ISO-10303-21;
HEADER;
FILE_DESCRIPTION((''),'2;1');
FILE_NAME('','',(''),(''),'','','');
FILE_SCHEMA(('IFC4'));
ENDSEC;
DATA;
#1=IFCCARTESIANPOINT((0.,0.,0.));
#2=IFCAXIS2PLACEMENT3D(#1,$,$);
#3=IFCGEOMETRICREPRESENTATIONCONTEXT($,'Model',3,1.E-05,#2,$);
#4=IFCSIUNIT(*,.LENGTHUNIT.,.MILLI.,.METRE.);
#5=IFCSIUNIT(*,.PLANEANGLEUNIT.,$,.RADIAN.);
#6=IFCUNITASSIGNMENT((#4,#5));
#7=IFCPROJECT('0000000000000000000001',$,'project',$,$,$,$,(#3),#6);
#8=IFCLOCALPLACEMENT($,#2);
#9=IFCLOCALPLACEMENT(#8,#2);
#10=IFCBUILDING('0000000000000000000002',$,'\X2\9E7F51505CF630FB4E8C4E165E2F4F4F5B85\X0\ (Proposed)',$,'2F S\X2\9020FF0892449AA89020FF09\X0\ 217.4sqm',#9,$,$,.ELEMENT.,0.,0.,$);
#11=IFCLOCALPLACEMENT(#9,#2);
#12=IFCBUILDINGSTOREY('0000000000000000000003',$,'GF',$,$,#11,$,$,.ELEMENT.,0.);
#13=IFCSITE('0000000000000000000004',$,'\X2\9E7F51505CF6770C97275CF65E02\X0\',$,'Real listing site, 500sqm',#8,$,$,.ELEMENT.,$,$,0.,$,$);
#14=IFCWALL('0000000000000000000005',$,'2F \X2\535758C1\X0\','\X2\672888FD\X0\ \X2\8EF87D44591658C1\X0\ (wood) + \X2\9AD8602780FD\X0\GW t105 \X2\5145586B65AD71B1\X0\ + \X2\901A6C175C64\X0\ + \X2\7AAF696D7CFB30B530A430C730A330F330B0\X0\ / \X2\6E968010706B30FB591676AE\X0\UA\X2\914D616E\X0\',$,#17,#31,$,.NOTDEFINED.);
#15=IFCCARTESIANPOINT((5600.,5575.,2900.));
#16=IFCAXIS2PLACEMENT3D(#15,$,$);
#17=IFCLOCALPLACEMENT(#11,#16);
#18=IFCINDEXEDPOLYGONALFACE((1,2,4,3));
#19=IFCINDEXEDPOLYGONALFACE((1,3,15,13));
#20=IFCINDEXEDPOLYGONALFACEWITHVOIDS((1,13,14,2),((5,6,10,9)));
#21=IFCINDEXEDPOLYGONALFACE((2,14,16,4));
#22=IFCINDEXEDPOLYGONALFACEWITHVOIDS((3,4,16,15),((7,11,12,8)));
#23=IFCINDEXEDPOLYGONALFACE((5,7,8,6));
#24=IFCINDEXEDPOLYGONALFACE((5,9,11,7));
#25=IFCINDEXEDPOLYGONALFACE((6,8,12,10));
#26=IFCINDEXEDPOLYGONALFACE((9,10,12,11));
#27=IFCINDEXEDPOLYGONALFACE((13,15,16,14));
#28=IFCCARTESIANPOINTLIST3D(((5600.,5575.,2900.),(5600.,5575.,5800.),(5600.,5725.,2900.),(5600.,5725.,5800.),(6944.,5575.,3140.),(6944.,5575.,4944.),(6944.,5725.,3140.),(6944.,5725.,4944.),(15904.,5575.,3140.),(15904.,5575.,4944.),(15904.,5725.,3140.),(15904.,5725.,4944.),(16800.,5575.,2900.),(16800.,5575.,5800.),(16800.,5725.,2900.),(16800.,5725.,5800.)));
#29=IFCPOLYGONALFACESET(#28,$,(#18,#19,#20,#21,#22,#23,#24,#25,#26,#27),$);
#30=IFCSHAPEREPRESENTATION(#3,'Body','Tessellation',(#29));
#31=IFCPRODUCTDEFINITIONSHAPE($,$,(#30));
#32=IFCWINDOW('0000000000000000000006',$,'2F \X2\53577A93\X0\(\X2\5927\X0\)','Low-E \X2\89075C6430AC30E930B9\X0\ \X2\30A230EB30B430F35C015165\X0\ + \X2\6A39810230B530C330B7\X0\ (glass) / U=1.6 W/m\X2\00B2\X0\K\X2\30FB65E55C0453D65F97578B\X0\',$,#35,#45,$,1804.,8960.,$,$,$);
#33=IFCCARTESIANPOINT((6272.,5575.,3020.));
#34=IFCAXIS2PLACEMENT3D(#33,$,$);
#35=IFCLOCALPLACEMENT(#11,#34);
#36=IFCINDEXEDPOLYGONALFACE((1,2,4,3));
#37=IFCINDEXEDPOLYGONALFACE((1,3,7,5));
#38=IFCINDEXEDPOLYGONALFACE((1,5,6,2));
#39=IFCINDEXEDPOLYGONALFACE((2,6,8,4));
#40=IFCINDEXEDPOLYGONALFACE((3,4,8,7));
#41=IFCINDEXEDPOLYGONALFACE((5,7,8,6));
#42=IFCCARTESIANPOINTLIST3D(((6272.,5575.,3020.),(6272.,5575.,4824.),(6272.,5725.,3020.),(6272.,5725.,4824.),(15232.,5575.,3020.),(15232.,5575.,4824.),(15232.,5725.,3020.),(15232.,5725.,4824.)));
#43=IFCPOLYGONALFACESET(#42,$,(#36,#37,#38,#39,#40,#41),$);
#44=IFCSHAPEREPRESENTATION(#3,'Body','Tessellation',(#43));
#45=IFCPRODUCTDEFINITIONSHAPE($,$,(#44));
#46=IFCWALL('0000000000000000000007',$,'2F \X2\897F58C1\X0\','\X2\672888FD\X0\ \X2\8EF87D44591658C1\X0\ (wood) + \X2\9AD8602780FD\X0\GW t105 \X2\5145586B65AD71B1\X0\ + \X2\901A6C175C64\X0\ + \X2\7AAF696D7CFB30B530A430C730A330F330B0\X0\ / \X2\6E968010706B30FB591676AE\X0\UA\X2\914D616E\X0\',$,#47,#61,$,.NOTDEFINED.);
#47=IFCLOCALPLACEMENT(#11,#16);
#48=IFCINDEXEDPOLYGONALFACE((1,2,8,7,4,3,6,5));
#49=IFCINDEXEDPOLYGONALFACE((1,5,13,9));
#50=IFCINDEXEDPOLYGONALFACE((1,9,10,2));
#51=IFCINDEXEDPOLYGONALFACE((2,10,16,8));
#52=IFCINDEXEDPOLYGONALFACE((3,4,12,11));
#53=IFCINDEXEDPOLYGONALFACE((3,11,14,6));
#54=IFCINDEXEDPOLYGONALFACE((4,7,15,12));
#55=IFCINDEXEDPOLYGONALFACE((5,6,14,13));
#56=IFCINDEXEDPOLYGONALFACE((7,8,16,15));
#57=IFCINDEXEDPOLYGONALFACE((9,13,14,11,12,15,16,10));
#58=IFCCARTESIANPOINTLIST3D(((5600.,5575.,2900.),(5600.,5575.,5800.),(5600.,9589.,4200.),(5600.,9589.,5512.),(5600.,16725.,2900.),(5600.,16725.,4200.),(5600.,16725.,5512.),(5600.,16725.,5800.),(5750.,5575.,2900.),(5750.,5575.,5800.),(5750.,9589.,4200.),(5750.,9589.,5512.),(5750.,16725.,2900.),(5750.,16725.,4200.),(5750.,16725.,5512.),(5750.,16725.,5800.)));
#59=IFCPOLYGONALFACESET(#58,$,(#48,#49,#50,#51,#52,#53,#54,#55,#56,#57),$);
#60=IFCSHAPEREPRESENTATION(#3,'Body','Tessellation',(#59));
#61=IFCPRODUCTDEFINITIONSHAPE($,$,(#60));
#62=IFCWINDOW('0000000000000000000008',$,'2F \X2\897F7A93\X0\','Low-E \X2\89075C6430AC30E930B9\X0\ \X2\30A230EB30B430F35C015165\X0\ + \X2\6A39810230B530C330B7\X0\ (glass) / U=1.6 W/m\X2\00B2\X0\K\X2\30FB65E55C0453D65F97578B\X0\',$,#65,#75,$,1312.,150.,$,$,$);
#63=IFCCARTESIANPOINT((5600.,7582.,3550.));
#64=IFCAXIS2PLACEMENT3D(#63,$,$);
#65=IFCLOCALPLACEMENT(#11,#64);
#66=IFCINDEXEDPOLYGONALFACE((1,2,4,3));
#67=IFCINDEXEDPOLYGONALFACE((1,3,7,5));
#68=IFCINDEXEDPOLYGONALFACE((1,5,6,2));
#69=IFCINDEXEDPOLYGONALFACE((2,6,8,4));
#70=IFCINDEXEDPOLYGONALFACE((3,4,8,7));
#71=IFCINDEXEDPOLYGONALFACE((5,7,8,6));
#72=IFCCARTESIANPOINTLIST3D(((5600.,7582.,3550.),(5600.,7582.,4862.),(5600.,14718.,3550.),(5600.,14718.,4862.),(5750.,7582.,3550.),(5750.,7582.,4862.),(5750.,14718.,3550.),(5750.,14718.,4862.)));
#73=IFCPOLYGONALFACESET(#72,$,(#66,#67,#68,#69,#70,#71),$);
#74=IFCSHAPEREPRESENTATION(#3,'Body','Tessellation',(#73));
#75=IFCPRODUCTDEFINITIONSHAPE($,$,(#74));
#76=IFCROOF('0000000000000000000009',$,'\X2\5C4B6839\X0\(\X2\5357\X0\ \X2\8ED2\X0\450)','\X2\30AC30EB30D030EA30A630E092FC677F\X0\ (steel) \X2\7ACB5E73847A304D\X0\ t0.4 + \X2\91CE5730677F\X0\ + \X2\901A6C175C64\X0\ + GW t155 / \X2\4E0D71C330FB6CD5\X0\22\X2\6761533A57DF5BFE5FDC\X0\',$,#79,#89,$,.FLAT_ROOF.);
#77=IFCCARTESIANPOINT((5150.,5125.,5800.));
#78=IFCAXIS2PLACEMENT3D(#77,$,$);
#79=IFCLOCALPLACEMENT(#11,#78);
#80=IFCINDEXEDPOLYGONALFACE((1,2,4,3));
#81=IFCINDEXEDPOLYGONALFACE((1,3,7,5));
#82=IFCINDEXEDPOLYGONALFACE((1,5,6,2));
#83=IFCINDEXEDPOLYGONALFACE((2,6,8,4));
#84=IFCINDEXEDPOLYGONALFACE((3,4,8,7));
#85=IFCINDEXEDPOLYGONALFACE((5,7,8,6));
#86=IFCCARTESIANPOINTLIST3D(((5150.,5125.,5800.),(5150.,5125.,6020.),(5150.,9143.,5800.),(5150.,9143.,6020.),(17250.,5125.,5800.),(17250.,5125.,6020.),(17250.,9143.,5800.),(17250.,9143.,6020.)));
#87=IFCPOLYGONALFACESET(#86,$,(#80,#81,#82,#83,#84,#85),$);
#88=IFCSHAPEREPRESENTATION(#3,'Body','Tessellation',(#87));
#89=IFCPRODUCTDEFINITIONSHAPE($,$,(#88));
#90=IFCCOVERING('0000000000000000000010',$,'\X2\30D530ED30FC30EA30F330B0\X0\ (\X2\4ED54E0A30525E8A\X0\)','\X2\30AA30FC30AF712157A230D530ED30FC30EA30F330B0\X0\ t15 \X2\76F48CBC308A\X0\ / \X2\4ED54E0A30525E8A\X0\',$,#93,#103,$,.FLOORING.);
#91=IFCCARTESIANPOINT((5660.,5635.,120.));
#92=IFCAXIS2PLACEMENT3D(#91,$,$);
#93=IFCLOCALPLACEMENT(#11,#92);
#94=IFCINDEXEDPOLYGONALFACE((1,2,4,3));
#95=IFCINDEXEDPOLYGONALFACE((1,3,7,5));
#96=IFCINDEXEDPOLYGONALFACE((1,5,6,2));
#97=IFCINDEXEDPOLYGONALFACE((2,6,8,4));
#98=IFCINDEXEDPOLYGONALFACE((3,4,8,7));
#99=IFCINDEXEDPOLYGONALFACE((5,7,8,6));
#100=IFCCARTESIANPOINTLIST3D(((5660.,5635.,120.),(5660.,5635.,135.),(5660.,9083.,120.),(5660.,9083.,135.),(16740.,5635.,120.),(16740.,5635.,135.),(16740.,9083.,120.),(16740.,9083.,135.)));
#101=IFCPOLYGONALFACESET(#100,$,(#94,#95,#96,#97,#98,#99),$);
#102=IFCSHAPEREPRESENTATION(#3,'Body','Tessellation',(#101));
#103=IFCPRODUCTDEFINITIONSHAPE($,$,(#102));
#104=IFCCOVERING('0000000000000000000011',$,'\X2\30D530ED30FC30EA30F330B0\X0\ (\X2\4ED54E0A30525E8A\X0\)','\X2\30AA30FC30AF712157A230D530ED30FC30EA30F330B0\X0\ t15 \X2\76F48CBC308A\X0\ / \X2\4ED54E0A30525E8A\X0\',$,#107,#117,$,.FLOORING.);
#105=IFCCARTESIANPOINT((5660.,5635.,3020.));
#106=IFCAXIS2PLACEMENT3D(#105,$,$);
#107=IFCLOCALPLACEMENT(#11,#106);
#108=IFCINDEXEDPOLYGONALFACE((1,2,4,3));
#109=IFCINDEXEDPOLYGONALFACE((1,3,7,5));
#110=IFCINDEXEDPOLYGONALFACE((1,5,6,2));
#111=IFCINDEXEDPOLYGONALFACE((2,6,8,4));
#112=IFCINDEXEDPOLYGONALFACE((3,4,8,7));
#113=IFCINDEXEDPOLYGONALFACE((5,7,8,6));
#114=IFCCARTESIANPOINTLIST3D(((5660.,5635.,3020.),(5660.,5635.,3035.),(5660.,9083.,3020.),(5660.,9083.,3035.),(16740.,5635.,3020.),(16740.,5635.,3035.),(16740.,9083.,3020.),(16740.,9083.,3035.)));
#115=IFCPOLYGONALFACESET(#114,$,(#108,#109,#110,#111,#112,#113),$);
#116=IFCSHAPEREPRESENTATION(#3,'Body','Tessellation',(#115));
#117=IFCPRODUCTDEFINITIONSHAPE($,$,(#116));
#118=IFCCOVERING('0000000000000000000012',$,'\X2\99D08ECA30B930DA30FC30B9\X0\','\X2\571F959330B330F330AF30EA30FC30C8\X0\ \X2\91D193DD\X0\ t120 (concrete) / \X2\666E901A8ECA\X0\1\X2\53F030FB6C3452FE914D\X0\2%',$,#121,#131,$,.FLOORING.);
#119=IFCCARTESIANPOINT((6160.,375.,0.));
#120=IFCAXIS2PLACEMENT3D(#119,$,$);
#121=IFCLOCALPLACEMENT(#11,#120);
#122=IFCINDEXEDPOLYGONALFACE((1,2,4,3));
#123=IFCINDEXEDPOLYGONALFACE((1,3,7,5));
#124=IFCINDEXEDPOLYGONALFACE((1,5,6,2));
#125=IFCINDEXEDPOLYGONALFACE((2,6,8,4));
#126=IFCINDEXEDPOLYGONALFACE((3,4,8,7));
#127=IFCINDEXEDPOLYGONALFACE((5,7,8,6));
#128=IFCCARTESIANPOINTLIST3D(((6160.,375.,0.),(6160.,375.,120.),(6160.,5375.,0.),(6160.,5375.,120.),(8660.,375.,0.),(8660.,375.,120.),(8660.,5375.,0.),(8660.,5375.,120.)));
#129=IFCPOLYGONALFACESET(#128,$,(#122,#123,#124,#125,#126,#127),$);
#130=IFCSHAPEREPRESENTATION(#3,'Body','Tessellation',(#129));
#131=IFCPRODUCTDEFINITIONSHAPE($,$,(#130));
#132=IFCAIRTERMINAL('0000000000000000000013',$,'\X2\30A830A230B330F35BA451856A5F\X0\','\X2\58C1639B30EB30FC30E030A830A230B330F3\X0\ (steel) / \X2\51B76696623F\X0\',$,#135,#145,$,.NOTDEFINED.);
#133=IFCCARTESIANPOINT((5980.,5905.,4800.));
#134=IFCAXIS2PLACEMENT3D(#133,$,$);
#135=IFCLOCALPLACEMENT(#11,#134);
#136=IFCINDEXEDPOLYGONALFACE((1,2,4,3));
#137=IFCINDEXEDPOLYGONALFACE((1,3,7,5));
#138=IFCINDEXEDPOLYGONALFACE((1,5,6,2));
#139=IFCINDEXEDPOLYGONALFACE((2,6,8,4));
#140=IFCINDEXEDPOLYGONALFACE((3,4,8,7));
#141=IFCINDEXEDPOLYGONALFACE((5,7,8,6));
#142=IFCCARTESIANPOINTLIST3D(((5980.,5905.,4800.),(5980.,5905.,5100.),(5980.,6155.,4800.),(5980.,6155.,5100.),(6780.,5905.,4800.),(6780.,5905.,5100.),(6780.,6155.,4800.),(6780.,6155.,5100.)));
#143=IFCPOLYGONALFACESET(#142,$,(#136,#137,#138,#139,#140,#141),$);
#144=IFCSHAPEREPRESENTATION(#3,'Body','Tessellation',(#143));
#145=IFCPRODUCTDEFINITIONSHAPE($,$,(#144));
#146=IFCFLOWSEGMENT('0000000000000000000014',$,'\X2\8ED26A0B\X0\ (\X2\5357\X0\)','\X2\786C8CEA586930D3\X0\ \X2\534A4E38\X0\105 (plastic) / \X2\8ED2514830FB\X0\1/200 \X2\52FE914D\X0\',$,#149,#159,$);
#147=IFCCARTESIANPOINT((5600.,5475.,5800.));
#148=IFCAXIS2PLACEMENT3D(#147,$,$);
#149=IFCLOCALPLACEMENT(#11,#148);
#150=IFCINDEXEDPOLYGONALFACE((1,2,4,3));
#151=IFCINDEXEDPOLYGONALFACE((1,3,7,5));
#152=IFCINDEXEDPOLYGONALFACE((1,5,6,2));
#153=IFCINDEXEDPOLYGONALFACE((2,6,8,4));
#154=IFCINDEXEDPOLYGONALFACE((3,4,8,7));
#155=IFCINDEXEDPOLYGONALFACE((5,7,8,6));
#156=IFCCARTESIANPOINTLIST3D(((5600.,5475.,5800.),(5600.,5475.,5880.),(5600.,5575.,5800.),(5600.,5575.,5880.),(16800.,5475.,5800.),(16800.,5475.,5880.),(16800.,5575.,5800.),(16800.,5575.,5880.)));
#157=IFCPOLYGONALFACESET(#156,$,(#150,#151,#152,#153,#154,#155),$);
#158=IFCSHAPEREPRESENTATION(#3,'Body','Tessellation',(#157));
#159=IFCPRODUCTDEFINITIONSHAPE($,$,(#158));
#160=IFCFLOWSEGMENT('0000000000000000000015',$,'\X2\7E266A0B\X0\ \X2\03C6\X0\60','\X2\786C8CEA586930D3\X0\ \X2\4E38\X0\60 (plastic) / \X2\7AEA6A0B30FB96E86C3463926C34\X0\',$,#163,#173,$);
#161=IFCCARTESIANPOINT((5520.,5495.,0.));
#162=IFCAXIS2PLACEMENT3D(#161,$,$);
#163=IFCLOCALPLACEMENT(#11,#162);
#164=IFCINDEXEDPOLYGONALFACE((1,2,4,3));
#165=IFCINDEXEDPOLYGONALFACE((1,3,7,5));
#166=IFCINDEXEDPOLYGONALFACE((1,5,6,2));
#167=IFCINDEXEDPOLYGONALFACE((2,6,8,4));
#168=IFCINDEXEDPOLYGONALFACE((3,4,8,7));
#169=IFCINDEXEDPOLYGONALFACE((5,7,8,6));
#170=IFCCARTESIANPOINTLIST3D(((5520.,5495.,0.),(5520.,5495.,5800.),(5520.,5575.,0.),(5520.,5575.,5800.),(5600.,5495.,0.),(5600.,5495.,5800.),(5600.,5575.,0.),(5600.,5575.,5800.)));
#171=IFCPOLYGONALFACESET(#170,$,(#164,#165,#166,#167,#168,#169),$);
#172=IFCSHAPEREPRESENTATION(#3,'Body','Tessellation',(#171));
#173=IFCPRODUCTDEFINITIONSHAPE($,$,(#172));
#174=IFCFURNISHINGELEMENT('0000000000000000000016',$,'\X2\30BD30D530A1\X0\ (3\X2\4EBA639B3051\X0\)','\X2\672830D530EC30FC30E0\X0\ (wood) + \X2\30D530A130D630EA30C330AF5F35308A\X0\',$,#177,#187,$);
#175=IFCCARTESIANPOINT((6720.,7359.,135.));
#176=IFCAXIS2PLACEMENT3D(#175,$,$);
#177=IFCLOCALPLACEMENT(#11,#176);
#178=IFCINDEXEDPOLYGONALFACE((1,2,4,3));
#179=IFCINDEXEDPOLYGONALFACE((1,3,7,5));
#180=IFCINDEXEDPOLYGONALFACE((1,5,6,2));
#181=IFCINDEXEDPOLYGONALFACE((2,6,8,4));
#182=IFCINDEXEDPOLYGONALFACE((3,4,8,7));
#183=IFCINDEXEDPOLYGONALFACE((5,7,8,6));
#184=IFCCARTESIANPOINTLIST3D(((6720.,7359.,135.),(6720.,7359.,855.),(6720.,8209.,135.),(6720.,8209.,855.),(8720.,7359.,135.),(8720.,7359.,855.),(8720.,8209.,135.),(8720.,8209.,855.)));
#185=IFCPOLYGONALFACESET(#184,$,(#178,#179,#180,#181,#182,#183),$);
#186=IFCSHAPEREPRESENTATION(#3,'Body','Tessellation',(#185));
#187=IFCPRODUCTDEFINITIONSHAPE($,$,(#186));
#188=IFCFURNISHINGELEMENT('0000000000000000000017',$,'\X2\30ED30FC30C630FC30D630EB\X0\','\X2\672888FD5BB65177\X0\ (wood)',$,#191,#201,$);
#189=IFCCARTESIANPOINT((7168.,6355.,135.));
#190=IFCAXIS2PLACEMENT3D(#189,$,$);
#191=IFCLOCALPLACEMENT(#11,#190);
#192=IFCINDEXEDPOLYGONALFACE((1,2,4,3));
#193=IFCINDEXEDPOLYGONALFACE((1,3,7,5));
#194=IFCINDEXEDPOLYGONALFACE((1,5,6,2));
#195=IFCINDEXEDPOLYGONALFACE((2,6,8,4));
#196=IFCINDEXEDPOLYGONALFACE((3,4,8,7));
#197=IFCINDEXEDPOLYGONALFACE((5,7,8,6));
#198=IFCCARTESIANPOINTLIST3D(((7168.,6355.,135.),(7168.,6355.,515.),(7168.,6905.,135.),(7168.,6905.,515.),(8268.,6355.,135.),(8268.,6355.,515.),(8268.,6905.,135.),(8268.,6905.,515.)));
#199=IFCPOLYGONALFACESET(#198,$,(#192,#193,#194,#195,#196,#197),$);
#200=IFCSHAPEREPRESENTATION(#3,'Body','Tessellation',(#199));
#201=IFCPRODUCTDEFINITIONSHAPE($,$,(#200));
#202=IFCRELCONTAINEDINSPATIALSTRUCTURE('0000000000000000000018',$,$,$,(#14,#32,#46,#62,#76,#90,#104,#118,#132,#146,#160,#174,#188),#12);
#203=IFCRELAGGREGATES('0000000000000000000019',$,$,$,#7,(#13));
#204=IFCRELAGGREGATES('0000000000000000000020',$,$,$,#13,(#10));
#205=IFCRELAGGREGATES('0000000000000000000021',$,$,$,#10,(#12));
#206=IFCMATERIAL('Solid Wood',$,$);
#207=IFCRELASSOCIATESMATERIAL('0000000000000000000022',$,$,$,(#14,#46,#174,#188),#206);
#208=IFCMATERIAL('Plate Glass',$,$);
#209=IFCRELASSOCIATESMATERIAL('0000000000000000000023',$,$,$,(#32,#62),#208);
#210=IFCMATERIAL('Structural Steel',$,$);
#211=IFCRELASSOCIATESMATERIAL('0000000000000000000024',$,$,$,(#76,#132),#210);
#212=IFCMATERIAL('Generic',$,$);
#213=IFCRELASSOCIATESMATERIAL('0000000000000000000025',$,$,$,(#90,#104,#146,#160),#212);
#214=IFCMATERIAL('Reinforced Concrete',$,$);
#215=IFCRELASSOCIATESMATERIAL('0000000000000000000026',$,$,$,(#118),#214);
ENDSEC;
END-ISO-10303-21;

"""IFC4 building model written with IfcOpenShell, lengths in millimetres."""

from ifc_helpers import new_model, si_unit, frame, frame_2d, origin, place, context, project, spatial, rectangle, extrude, material, element, fill, save


model = new_model("IFC4")

# Units and contexts
model_context = context("Model", 3, precision=1e-05, world=origin())
ifc_project = project(units=[si_unit("LENGTHUNIT", "METRE", prefix="MILLI"), si_unit("PLANEANGLEUNIT", "RADIAN")], contexts=[model_context])

# Site, building, storey
site_placement = place(None, origin())
site = spatial("IfcSite", under=ifc_project, at=site_placement, Name="鹿児島県霧島市", ObjectType="Real listing site, 500sqm", CompositionType="ELEMENT", RefElevation=0.0)
building_placement = place(site_placement, origin())
building = spatial("IfcBuilding", under=site, at=building_placement, Name="鹿児島・二世帯住宅 (Proposed)", ObjectType="2F S造（鉄骨造） 217.4sqm", CompositionType="ELEMENT", ElevationOfRefHeight=0.0, ElevationOfTerrain=0.0)
storey_placement = place(building_placement, origin())
storey = spatial("IfcBuildingStorey", under=building, at=storey_placement, Name="GF", CompositionType="ELEMENT", Elevation=0.0)

# Shared definitions
ifc_material_1 = material(Name="Solid Wood")

# Shared definitions
ifc_material_2 = material(Name="Reinforced Concrete")

# Shared definitions
ifc_material_3 = material(Name="Plate Glass")

# Walls, openings, windows
wall_1_placement = place(storey_placement, frame((5600.0, 5575.0, 2900.0)))
wall_1 = element("IfcWall", 1, at=wall_1_placement, inside=storey, material=ifc_material_1, Name="2F 南壁", Description="木製 軸組外壁 (wood) + 高性能GW t105 充填断熱 + 通気層 + 窯業系サイディング / 準耐火・外皮UA配慮", PredefinedType="NOTDEFINED", context=model_context, shape_type="SweptSolid", body=[
    extrude(rectangle(XDim=11200.0, YDim=150.0, at=frame_2d((5600.0, 75.0))), frame((5600.0, 5575.0, 2900.0)), (0.0, 0.0, 1.0), 2900.0),
])
opening_1_placement = place(storey_placement, frame((6272.0, 5575.0, 3020.0)))
opening_1 = element("IfcOpeningElement", 2, at=opening_1_placement, cuts=wall_1, PredefinedType="NOTDEFINED", context=model_context, shape_type="SweptSolid", body=[
    extrude(rectangle(XDim=8960.0, YDim=150.0, at=frame_2d((4480.0, 75.0))), frame((6272.0, 5575.0, 3020.0)), (0.0, 0.0, 1.0), 1804.0),
])
window_1_placement = place(storey_placement, frame((6272.0, 5575.0, 3020.0)))
window_1 = element("IfcWindow", 3, at=window_1_placement, inside=storey, material=ifc_material_3, Name="2F 南窓(大)", Description="Low-E 複層ガラス アルゴン封入 + 樹脂サッシ (glass) / U=1.6 W/m²K・日射取得型", OverallHeight=1804.0, OverallWidth=8960.0, context=model_context, shape_type="SweptSolid", body=[
    extrude(rectangle(XDim=8960.0, YDim=150.0, at=frame_2d((4480.0, 75.0))), frame((6272.0, 5575.0, 3020.0)), (0.0, 0.0, 1.0), 1804.0),
])
fill(opening_1, window_1)
wall_2_placement = place(storey_placement, frame((5600.0, 5575.0, 2900.0)))
wall_2 = element("IfcWall", 4, at=wall_2_placement, inside=storey, material=ifc_material_1, Name="2F 西壁", Description="木製 軸組外壁 (wood) + 高性能GW t105 充填断熱 + 通気層 + 窯業系サイディング / 準耐火・外皮UA配慮", PredefinedType="NOTDEFINED", context=model_context, shape_type="SweptSolid", body=[
    extrude(rectangle(XDim=150.0, YDim=11150.0, at=frame_2d((75.0, 5575.0))), frame((5600.0, 5575.0, 2900.0)), (0.0, 0.0, 1.0), 2900.0),
])
opening_2_placement = place(storey_placement, frame((5600.0, 7582.0, 3550.0)))
opening_2 = element("IfcOpeningElement", 5, at=opening_2_placement, cuts=wall_2, PredefinedType="NOTDEFINED", context=model_context, shape_type="SweptSolid", body=[
    extrude(rectangle(XDim=150.0, YDim=7136.0, at=frame_2d((75.0, 3568.0))), frame((5600.0, 7582.0, 3550.0)), (0.0, 0.0, 1.0), 1312.0),
])
window_2_placement = place(storey_placement, frame((5600.0, 7582.0, 3550.0)))
window_2 = element("IfcWindow", 6, at=window_2_placement, inside=storey, material=ifc_material_3, Name="2F 西窓", Description="Low-E 複層ガラス アルゴン封入 + 樹脂サッシ (glass) / U=1.6 W/m²K・日射取得型", OverallHeight=1312.0, OverallWidth=150.0, context=model_context, shape_type="SweptSolid", body=[
    extrude(rectangle(XDim=150.0, YDim=7136.0, at=frame_2d((75.0, 3568.0))), frame((5600.0, 7582.0, 3550.0)), (0.0, 0.0, 1.0), 1312.0),
])
fill(opening_2, window_2)

# Roof
ifc_material_4 = material(Name="Structural Steel")
for number, where, name in (
    (7, (5150.0, 5125.0, 5800.0), "屋根(南 軒450)"),
):
    element("IfcRoof", number, at=place(storey_placement, frame(where)), inside=storey, material=ifc_material_4, Name=name, Description="ガルバリウム鋼板 (steel) 立平葺き t0.4 + 野地板 + 通気層 + GW t155 / 不燃・法22条区域対応", PredefinedType="FLAT_ROOF", context=model_context, shape_type="SweptSolid", body=[
        extrude(rectangle(XDim=12100.0, YDim=4018.0, at=frame_2d((6050.0, 2009.0))), frame((5150.0, 5125.0, 5800.0)), (0.0, 0.0, 1.0), 220.0),
    ])

# Coverings
ifc_material_5 = material(Name="Generic")
covering_1_placement = place(storey_placement, frame((5660.0, 5635.0, 120.0)))
element("IfcCovering", 8, at=covering_1_placement, inside=storey, material=ifc_material_5, Name="フローリング (仕上げ床)", Description="オーク無垢フローリング t15 直貼り / 仕上げ床", PredefinedType="FLOORING", context=model_context, shape_type="SweptSolid", body=[
    extrude(rectangle(XDim=11080.0, YDim=3448.0, at=frame_2d((5540.0, 1724.0))), frame((5660.0, 5635.0, 120.0)), (0.0, 0.0, 1.0), 15.0),
])
covering_2_placement = place(storey_placement, frame((5660.0, 5635.0, 3020.0)))
element("IfcCovering", 9, at=covering_2_placement, inside=storey, material=ifc_material_5, Name="フローリング (仕上げ床)", Description="オーク無垢フローリング t15 直貼り / 仕上げ床", PredefinedType="FLOORING", context=model_context, shape_type="SweptSolid", body=[
    extrude(rectangle(XDim=11080.0, YDim=3448.0, at=frame_2d((5540.0, 1724.0))), frame((5660.0, 5635.0, 3020.0)), (0.0, 0.0, 1.0), 15.0),
])
covering_3_placement = place(storey_placement, frame((6160.0, 375.0, 0.0)))
element("IfcCovering", 10, at=covering_3_placement, inside=storey, material=ifc_material_2, Name="駐車スペース", Description="土間コンクリート 金鏝 t120 (concrete) / 普通車1台・水勾配2%", PredefinedType="FLOORING", context=model_context, shape_type="SweptSolid", body=[
    extrude(rectangle(XDim=2500.0, YDim=5000.0, at=frame_2d((1250.0, 2500.0))), frame((6160.0, 375.0, 0.0)), (0.0, 0.0, 1.0), 120.0),
])

# Air terminal
air_terminal_placement = place(storey_placement, frame((5980.0, 5905.0, 4800.0)))
element("IfcAirTerminal", 11, at=air_terminal_placement, inside=storey, material=ifc_material_4, Name="エアコン室内機", Description="壁掛ルームエアコン (steel) / 冷暖房", PredefinedType="NOTDEFINED", context=model_context, shape_type="SweptSolid", body=[
    extrude(rectangle(XDim=800.0, YDim=250.0, at=frame_2d((400.0, 125.0))), frame((5980.0, 5905.0, 4800.0)), (0.0, 0.0, 1.0), 300.0),
])

# Flow segments
flow_segment_1_placement = place(storey_placement, frame((5600.0, 5475.0, 5800.0)))
element("IfcFlowSegment", 12, at=flow_segment_1_placement, inside=storey, material=ifc_material_5, Name="軒樋 (南)", Description="硬質塩ビ 半丸105 (plastic) / 軒先・1/200 勾配", context=model_context, shape_type="SweptSolid", body=[
    extrude(rectangle(XDim=11200.0, YDim=100.0, at=frame_2d((5600.0, 50.0))), frame((5600.0, 5475.0, 5800.0)), (0.0, 0.0, 1.0), 80.0),
])
flow_segment_2_placement = place(storey_placement, frame((5520.0, 5495.0, 0.0)))
element("IfcFlowSegment", 13, at=flow_segment_2_placement, inside=storey, material=ifc_material_5, Name="縦樋 φ60", Description="硬質塩ビ 丸60 (plastic) / 竪樋・雨水排水", context=model_context, shape_type="SweptSolid", body=[
    extrude(rectangle(XDim=80.0, YDim=80.0, at=frame_2d((40.0, 40.0))), frame((5520.0, 5495.0, 0.0)), (0.0, 0.0, 1.0), 5800.0),
])

# Furnishing elements
furnishing_1_placement = place(storey_placement, frame((6720.0, 7359.0, 135.0)))
element("IfcFurnishingElement", 14, at=furnishing_1_placement, inside=storey, material=ifc_material_1, Name="ソファ (3人掛け)", Description="木フレーム (wood) + ファブリック張り", context=model_context, shape_type="SweptSolid", body=[
    extrude(rectangle(XDim=2000.0, YDim=850.0, at=frame_2d((1000.0, 425.0))), frame((6720.0, 7359.0, 135.0)), (0.0, 0.0, 1.0), 720.0),
])
furnishing_2_placement = place(storey_placement, frame((7168.0, 6355.0, 135.0)))
element("IfcFurnishingElement", 15, at=furnishing_2_placement, inside=storey, material=ifc_material_1, Name="ローテーブル", Description="木製家具 (wood)", context=model_context, shape_type="SweptSolid", body=[
    extrude(rectangle(XDim=1100.0, YDim=550.0, at=frame_2d((550.0, 275.0))), frame((7168.0, 6355.0, 135.0)), (0.0, 0.0, 1.0), 380.0),
])

save(model, "model.ifc")
